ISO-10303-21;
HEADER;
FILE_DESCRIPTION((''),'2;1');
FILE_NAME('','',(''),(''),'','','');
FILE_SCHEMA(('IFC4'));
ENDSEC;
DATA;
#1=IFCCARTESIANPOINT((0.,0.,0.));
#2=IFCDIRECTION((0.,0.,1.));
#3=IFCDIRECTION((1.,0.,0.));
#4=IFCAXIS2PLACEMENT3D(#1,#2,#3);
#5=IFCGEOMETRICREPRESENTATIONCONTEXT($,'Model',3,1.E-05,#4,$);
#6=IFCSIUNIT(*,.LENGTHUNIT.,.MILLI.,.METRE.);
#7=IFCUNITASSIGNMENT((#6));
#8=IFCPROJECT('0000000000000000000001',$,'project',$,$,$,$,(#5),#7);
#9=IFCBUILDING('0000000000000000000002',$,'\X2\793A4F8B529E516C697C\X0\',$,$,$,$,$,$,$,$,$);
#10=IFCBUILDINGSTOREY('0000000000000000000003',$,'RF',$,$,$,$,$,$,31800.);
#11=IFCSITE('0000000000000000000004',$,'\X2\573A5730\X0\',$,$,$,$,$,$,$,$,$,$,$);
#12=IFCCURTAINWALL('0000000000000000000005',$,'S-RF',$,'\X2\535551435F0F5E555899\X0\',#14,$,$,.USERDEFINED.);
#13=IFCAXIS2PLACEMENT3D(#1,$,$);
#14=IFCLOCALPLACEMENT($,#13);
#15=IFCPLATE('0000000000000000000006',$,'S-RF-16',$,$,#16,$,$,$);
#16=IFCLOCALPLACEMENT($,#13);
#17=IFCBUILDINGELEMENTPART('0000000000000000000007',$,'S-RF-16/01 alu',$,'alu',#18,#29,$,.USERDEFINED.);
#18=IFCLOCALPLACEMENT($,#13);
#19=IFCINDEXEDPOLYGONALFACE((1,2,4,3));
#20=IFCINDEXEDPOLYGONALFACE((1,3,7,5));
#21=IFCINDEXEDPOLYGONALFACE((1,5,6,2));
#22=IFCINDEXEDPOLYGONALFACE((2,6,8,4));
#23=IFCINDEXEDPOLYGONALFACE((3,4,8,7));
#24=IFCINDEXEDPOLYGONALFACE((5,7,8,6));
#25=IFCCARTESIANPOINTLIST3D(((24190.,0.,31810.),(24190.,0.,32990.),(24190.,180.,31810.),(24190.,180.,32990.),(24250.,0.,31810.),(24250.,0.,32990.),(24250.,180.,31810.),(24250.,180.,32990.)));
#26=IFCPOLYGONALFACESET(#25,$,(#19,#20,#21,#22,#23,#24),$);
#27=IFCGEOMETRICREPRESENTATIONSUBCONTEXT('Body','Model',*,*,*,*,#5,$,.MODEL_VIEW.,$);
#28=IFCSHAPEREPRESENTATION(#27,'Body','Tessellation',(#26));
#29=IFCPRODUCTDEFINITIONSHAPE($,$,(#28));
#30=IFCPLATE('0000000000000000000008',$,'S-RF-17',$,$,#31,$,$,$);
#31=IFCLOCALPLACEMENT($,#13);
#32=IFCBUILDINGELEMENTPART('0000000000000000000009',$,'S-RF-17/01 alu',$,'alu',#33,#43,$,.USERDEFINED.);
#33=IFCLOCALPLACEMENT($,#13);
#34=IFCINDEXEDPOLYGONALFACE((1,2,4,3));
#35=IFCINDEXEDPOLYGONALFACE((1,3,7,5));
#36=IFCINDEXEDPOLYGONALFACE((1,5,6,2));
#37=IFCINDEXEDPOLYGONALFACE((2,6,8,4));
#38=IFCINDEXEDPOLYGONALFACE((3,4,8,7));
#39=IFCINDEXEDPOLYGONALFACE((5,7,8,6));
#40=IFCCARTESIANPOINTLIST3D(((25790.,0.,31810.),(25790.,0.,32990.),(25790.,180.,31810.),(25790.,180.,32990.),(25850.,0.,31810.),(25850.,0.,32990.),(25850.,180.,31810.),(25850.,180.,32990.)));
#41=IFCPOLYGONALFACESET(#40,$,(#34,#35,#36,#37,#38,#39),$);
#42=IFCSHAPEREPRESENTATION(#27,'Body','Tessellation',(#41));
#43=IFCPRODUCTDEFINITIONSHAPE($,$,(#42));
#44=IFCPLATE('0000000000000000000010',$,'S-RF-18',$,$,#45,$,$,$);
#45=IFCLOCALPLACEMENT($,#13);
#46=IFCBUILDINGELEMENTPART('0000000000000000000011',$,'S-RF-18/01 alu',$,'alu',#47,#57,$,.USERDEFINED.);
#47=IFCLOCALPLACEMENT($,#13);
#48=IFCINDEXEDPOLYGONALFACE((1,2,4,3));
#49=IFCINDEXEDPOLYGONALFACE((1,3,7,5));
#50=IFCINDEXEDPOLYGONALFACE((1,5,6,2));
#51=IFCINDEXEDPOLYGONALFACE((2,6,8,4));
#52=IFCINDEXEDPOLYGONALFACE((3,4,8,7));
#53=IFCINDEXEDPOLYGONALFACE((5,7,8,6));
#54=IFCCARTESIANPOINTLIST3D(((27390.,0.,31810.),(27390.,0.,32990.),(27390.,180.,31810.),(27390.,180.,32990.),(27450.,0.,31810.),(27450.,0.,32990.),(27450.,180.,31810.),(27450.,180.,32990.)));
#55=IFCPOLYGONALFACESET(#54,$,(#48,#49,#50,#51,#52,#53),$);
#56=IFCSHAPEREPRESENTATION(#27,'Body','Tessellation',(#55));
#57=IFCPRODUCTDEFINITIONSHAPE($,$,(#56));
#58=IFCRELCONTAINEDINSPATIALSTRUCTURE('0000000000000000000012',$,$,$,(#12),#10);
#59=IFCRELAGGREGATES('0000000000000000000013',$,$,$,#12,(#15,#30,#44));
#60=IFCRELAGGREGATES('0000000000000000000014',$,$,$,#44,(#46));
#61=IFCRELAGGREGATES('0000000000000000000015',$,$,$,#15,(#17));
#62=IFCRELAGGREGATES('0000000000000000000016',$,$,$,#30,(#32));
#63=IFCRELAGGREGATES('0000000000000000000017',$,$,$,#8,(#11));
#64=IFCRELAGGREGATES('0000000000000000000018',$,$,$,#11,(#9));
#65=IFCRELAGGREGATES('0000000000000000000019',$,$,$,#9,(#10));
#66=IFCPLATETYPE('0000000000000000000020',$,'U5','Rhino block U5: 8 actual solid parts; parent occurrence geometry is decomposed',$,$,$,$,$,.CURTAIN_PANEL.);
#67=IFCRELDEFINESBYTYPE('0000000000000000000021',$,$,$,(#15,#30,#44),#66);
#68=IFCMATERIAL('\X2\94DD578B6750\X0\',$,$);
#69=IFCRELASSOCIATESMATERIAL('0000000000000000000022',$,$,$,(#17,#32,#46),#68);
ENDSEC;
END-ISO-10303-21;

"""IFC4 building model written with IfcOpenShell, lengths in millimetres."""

from ifc_helpers import new_model, si_unit, frame, frame_2d, origin, origin_with_axes, place, context, subcontext, project, spatial, rectangle, extrude, source, transform, mapped, material, type_object, element, aggregate, save


model = new_model("IFC4")

# Units and contexts
model_context = context("Model", 3, precision=1e-05, world=origin_with_axes())
body_context = subcontext(model_context, "Body", "Model", "MODEL_VIEW")
ifc_project = project(units=[si_unit("LENGTHUNIT", "METRE", prefix="MILLI")], contexts=[model_context])

# Site, building, storey
site = spatial("IfcSite", under=ifc_project, Name="场地")
building = spatial("IfcBuilding", under=site, Name="示例办公楼")
storey = spatial("IfcBuildingStorey", under=building, Name="RF", Elevation=31800.0)

# Curtain wall, plates, building element parts
curtain_wall = element("IfcCurtainWall", 1, inside=storey, Name="S-RF", ObjectType="单元式幕墙", PredefinedType="USERDEFINED")
plate_type = type_object("IfcPlateType", Name="U5", Description="Rhino block U5: 8 actual solid parts; parent occurrence geometry is decomposed", PredefinedType="CURTAIN_PANEL")
plate_1_placement = place(None, frame((24190.0, 0.0, 31810.0), z_axis=(0.0, 0.0, 1.0), x_axis=(1.0, 0.0, 0.0)))
plate_1 = element("IfcPlate", 2, at=plate_1_placement, type_object=plate_type, Name="S-RF-16")
ifc_material_1 = material(Name="铝型材")
shared_shape_1 = source(origin(), body_context, "Body", "SweptSolid", [
    extrude(rectangle(XDim=60.0, YDim=180.0, at=frame_2d((30.0, 90.0))), origin(), (0.0, 0.0, 1.0), 1180.0),
])
building_element_part_1_placement = place(plate_1_placement, origin())
building_element_part_1 = element("IfcBuildingElementPart", 3, at=building_element_part_1_placement, material=ifc_material_1, Name="S-RF-16/01 alu", ObjectType="alu", PredefinedType="USERDEFINED", context=body_context, shape_type="MappedRepresentation", body=[
    mapped(shared_shape_1, transform((0.0, 0.0, 0.0))),
])
plate_2_placement = place(None, frame((25790.0, 0.0, 31810.0), z_axis=(0.0, 0.0, 1.0), x_axis=(1.0, 0.0, 0.0)))
plate_2 = element("IfcPlate", 4, at=plate_2_placement, type_object=plate_type, Name="S-RF-17")
building_element_part_2_placement = place(plate_2_placement, origin())
building_element_part_2 = element("IfcBuildingElementPart", 5, at=building_element_part_2_placement, material=ifc_material_1, Name="S-RF-17/01 alu", ObjectType="alu", PredefinedType="USERDEFINED", context=body_context, shape_type="MappedRepresentation", body=[
    mapped(shared_shape_1, transform((0.0, 0.0, 0.0))),
])
plate_3_placement = place(None, frame((27390.0, 0.0, 31810.0), z_axis=(0.0, 0.0, 1.0), x_axis=(1.0, 0.0, 0.0)))
plate_3 = element("IfcPlate", 6, at=plate_3_placement, type_object=plate_type, Name="S-RF-18")
aggregate(curtain_wall, [plate_1, plate_2, plate_3])
building_element_part_3_placement = place(plate_3_placement, origin())
building_element_part_3 = element("IfcBuildingElementPart", 7, at=building_element_part_3_placement, material=ifc_material_1, Name="S-RF-18/01 alu", ObjectType="alu", PredefinedType="USERDEFINED", context=body_context, shape_type="MappedRepresentation", body=[
    mapped(shared_shape_1, transform((0.0, 0.0, 0.0))),
])
aggregate(plate_3, [building_element_part_3])
aggregate(plate_1, [building_element_part_1])
aggregate(plate_2, [building_element_part_2])

save(model, "model.ifc")
